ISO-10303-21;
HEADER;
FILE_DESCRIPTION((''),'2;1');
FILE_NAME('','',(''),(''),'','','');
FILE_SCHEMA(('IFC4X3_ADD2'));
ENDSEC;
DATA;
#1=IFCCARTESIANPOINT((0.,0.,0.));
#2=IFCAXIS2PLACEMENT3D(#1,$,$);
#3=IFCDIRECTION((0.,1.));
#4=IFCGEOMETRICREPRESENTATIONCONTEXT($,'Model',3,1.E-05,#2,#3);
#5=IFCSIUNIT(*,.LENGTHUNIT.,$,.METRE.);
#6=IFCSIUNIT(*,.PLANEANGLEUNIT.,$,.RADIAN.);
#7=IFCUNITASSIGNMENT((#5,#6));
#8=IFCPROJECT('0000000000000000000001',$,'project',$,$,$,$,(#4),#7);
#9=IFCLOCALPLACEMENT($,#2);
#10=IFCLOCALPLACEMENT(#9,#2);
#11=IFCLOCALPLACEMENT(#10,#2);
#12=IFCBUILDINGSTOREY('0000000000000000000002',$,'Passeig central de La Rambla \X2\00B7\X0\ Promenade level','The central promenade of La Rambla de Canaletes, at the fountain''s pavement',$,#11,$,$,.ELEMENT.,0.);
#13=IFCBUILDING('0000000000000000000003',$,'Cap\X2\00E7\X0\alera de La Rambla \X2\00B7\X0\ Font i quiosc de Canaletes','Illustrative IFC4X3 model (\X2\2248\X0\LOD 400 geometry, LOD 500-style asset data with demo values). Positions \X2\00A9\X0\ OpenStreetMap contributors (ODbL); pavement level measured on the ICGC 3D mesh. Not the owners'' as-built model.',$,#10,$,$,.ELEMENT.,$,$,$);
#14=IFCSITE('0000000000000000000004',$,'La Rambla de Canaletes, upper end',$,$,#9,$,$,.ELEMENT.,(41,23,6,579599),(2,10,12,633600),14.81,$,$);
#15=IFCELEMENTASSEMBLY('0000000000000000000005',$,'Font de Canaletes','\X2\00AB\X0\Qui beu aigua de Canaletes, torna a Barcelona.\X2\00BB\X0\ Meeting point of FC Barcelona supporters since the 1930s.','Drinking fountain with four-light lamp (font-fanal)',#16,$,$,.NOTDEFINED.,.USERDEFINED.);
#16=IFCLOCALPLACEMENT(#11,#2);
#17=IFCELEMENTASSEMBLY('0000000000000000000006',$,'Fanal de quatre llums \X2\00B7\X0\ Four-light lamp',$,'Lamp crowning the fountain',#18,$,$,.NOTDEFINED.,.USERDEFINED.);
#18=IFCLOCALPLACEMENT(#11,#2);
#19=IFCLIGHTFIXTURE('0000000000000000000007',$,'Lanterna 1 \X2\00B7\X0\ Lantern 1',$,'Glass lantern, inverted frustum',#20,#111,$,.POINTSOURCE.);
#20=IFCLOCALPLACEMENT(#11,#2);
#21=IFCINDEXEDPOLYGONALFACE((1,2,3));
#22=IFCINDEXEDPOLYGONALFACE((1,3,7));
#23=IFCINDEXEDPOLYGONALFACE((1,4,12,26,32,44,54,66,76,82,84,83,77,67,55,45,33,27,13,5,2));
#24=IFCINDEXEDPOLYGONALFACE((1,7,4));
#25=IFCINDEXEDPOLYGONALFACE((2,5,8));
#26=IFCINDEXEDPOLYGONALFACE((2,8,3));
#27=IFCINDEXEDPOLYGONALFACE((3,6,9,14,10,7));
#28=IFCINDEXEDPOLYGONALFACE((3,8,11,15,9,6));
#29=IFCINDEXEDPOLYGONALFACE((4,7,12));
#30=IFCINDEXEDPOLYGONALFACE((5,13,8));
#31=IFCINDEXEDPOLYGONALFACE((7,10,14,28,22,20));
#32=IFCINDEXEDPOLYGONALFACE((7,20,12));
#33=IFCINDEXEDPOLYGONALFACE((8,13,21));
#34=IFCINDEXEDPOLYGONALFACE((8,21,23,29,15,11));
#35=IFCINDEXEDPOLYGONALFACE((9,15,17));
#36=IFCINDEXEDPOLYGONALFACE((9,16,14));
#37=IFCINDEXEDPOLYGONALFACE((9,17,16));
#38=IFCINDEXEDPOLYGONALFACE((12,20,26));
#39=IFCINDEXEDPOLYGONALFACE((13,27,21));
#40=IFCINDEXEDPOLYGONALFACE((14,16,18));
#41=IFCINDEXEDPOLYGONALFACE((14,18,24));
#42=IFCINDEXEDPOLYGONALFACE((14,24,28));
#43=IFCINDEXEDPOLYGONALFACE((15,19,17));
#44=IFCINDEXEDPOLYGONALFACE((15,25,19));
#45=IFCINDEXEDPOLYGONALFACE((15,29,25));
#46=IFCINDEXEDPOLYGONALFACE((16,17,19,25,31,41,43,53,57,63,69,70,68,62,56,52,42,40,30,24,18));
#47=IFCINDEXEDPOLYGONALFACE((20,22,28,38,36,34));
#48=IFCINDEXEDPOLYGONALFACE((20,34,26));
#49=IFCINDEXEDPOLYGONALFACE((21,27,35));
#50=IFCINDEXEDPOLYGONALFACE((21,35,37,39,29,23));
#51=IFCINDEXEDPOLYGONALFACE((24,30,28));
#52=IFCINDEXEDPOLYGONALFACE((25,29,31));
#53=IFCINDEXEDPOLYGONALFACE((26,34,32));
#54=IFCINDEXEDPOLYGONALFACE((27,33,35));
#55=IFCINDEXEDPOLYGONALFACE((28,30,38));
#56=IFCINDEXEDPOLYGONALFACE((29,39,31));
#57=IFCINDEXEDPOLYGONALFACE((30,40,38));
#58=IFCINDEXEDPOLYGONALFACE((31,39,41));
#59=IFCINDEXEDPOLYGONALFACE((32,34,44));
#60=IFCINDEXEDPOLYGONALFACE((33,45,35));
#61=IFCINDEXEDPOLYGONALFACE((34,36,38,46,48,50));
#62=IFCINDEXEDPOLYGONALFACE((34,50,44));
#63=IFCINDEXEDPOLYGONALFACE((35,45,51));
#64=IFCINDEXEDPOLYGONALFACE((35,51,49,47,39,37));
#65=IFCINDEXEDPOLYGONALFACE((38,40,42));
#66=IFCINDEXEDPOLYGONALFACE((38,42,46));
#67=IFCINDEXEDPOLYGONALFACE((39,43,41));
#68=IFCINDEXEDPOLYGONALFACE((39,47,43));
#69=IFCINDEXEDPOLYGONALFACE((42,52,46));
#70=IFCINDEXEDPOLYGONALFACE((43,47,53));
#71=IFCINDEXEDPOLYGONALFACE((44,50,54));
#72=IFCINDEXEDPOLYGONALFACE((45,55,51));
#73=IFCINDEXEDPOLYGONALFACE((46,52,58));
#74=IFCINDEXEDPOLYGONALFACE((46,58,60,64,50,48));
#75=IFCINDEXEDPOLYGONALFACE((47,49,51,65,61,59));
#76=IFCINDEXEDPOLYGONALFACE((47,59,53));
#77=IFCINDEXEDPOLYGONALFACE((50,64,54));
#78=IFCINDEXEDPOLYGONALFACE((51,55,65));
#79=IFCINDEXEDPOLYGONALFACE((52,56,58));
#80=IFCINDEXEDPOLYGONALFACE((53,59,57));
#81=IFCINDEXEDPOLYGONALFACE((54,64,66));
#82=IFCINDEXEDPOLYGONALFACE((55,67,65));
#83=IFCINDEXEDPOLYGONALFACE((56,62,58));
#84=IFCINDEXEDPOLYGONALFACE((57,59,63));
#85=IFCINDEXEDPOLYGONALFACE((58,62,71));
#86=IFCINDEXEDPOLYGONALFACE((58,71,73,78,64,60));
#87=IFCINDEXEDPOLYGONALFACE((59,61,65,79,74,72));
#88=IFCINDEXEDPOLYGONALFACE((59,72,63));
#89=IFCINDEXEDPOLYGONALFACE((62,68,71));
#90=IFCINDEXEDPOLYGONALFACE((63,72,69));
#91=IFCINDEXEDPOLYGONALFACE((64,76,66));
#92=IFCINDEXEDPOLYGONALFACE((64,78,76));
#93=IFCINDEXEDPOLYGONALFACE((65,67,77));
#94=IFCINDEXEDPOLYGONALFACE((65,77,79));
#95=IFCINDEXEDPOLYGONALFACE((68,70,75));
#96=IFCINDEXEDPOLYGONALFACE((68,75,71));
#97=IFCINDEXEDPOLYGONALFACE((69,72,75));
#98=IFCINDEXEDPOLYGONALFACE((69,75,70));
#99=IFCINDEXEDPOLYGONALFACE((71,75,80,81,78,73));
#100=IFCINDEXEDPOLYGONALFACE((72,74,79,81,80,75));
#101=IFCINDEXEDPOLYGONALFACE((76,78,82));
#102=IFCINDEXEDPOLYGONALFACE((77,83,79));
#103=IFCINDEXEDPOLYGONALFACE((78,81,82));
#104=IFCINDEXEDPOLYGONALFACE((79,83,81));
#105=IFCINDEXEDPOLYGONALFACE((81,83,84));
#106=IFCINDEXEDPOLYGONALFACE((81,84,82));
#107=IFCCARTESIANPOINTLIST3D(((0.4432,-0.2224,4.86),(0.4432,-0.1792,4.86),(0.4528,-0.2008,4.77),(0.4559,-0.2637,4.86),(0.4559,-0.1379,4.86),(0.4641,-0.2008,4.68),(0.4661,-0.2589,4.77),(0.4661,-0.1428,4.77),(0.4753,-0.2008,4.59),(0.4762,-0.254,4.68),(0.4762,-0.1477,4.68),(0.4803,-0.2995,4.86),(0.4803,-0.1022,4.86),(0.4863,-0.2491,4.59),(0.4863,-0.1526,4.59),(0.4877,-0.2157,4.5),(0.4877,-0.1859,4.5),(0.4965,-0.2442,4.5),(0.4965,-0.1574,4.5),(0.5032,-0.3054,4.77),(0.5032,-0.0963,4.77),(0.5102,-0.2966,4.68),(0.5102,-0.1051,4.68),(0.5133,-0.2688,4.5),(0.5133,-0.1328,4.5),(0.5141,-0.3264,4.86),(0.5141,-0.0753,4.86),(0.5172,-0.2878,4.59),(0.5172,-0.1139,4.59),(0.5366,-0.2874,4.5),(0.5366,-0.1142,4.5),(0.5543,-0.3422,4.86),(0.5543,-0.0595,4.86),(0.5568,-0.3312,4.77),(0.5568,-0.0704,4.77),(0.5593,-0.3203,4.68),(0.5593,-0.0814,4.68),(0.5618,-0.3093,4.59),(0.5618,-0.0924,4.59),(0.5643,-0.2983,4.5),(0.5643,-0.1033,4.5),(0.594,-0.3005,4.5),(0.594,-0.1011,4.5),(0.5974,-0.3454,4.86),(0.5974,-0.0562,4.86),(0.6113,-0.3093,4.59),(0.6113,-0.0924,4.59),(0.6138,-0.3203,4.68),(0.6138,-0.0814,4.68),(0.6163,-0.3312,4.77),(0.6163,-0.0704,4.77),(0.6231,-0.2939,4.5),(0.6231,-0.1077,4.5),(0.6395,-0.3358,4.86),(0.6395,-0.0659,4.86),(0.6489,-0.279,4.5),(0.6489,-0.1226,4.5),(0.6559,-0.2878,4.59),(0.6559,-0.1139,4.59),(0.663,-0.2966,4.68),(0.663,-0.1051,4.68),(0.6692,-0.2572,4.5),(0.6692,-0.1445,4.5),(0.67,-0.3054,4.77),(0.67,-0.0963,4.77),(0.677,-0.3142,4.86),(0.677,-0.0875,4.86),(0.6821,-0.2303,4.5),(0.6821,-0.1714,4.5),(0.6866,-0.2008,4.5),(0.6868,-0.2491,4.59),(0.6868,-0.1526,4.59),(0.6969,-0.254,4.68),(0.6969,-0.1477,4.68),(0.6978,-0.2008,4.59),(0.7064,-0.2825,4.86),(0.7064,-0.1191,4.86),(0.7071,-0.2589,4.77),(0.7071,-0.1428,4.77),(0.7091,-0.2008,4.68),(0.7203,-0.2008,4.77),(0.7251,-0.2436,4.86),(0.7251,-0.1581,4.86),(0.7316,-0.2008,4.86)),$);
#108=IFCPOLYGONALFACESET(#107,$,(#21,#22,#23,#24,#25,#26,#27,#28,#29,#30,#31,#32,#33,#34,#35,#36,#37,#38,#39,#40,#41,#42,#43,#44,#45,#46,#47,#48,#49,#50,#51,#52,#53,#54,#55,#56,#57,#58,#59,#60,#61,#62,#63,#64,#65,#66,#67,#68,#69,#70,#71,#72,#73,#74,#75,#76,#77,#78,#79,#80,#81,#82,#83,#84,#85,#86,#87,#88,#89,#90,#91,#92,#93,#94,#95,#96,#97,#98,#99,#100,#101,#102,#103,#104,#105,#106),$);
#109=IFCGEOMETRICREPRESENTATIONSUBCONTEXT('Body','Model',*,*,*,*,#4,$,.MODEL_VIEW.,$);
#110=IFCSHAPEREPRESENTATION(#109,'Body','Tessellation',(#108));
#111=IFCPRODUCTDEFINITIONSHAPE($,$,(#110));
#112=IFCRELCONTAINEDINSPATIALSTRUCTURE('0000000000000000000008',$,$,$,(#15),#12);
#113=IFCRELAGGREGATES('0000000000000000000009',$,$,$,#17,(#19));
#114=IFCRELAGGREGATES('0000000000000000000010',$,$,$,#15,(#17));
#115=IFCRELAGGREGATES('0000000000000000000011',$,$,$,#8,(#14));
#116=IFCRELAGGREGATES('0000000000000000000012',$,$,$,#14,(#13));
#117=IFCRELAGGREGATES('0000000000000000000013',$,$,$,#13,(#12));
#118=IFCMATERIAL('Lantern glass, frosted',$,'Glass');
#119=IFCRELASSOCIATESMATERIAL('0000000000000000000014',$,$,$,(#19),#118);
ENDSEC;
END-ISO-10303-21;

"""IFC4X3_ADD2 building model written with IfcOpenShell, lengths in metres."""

from ifc_helpers import new_model, entity, si_unit, direction, origin, place, context, subcontext, project, spatial, material, element, aggregate, save


model = new_model("IFC4X3_ADD2")

# Units and contexts
model_context = context("Model", 3, precision=1e-05, world=origin(), true_north=direction((0.0, 1.0)))
body_context = subcontext(model_context, "Body", "Model", "MODEL_VIEW")
ifc_project = project(units=[si_unit("LENGTHUNIT", "METRE"), si_unit("PLANEANGLEUNIT", "RADIAN")], contexts=[model_context])

# Site, building, storey
site_placement = place(None, origin())
site = spatial("IfcSite", under=ifc_project, at=site_placement, Name="La Rambla de Canaletes, upper end", CompositionType="ELEMENT", RefLatitude=(41, 23, 6, 579599), RefLongitude=(2, 10, 12, 633600), RefElevation=14.81)
building_placement = place(site_placement, origin())
building = spatial("IfcBuilding", under=site, at=building_placement, Name="Capçalera de La Rambla · Font i quiosc de Canaletes", Description="Illustrative IFC4X3 model (≈LOD 400 geometry, LOD 500-style asset data with demo values). Positions © OpenStreetMap contributors (ODbL); pavement level measured on the ICGC 3D mesh. Not the owners' as-built model.", CompositionType="ELEMENT")
storey_placement = place(building_placement, origin())
storey = spatial("IfcBuildingStorey", under=building, at=storey_placement, Name="Passeig central de La Rambla · Promenade level", Description="The central promenade of La Rambla de Canaletes, at the fountain's pavement", CompositionType="ELEMENT", Elevation=0.0)

# Element assemblies, light fixture
assembly_1_placement = place(building_placement, origin())
assembly_1 = element("IfcElementAssembly", 1, at=assembly_1_placement, inside=storey, Name="Font de Canaletes", Description="«Qui beu aigua de Canaletes, torna a Barcelona.» Meeting point of FC Barcelona supporters since the 1930s.", ObjectType="Drinking fountain with four-light lamp (font-fanal)", AssemblyPlace="NOTDEFINED", PredefinedType="USERDEFINED")
assembly_2_placement = place(building_placement, origin())
assembly_2 = element("IfcElementAssembly", 2, at=assembly_2_placement, Name="Fanal de quatre llums · Four-light lamp", ObjectType="Lamp crowning the fountain", AssemblyPlace="NOTDEFINED", PredefinedType="USERDEFINED")
ifc_material_1 = material(Name="Lantern glass, frosted", Category="Glass")
light_fixture_1_placement = place(building_placement, origin())
light_fixture_1 = element("IfcLightFixture", 3, at=light_fixture_1_placement, material=ifc_material_1, Name="Lanterna 1 · Lantern 1", ObjectType="Glass lantern, inverted frustum", PredefinedType="POINTSOURCE", context=body_context, shape_type="SweptSolid", body=[
    entity("IfcRevolvedAreaSolid", entity("IfcArbitraryClosedProfileDef", "AREA", None, entity("IfcPolyline", [entity("IfcCartesianPoint", [0.0, 0.0]), entity("IfcCartesianPoint", [0.1, 0.0]), entity("IfcCartesianPoint", [0.145, 0.36]), entity("IfcCartesianPoint", [0.0, 0.36]), entity("IfcCartesianPoint", [0.0, 0.0])])), entity("IfcAxis2Placement3D", entity("IfcCartesianPoint", [0.5866, -0.2008, 4.5]), entity("IfcDirection", [0.0, -1.0, 0.0]), entity("IfcDirection", [1.0, 0.0, 0.0])), entity("IfcAxis1Placement", entity("IfcCartesianPoint", [0.0, 0.0, 0.0]), entity("IfcDirection", [0.0, 1.0, 0.0])), 6.283185),
])
aggregate(assembly_2, [light_fixture_1])
aggregate(assembly_1, [assembly_2])

save(model, "model.ifc")
